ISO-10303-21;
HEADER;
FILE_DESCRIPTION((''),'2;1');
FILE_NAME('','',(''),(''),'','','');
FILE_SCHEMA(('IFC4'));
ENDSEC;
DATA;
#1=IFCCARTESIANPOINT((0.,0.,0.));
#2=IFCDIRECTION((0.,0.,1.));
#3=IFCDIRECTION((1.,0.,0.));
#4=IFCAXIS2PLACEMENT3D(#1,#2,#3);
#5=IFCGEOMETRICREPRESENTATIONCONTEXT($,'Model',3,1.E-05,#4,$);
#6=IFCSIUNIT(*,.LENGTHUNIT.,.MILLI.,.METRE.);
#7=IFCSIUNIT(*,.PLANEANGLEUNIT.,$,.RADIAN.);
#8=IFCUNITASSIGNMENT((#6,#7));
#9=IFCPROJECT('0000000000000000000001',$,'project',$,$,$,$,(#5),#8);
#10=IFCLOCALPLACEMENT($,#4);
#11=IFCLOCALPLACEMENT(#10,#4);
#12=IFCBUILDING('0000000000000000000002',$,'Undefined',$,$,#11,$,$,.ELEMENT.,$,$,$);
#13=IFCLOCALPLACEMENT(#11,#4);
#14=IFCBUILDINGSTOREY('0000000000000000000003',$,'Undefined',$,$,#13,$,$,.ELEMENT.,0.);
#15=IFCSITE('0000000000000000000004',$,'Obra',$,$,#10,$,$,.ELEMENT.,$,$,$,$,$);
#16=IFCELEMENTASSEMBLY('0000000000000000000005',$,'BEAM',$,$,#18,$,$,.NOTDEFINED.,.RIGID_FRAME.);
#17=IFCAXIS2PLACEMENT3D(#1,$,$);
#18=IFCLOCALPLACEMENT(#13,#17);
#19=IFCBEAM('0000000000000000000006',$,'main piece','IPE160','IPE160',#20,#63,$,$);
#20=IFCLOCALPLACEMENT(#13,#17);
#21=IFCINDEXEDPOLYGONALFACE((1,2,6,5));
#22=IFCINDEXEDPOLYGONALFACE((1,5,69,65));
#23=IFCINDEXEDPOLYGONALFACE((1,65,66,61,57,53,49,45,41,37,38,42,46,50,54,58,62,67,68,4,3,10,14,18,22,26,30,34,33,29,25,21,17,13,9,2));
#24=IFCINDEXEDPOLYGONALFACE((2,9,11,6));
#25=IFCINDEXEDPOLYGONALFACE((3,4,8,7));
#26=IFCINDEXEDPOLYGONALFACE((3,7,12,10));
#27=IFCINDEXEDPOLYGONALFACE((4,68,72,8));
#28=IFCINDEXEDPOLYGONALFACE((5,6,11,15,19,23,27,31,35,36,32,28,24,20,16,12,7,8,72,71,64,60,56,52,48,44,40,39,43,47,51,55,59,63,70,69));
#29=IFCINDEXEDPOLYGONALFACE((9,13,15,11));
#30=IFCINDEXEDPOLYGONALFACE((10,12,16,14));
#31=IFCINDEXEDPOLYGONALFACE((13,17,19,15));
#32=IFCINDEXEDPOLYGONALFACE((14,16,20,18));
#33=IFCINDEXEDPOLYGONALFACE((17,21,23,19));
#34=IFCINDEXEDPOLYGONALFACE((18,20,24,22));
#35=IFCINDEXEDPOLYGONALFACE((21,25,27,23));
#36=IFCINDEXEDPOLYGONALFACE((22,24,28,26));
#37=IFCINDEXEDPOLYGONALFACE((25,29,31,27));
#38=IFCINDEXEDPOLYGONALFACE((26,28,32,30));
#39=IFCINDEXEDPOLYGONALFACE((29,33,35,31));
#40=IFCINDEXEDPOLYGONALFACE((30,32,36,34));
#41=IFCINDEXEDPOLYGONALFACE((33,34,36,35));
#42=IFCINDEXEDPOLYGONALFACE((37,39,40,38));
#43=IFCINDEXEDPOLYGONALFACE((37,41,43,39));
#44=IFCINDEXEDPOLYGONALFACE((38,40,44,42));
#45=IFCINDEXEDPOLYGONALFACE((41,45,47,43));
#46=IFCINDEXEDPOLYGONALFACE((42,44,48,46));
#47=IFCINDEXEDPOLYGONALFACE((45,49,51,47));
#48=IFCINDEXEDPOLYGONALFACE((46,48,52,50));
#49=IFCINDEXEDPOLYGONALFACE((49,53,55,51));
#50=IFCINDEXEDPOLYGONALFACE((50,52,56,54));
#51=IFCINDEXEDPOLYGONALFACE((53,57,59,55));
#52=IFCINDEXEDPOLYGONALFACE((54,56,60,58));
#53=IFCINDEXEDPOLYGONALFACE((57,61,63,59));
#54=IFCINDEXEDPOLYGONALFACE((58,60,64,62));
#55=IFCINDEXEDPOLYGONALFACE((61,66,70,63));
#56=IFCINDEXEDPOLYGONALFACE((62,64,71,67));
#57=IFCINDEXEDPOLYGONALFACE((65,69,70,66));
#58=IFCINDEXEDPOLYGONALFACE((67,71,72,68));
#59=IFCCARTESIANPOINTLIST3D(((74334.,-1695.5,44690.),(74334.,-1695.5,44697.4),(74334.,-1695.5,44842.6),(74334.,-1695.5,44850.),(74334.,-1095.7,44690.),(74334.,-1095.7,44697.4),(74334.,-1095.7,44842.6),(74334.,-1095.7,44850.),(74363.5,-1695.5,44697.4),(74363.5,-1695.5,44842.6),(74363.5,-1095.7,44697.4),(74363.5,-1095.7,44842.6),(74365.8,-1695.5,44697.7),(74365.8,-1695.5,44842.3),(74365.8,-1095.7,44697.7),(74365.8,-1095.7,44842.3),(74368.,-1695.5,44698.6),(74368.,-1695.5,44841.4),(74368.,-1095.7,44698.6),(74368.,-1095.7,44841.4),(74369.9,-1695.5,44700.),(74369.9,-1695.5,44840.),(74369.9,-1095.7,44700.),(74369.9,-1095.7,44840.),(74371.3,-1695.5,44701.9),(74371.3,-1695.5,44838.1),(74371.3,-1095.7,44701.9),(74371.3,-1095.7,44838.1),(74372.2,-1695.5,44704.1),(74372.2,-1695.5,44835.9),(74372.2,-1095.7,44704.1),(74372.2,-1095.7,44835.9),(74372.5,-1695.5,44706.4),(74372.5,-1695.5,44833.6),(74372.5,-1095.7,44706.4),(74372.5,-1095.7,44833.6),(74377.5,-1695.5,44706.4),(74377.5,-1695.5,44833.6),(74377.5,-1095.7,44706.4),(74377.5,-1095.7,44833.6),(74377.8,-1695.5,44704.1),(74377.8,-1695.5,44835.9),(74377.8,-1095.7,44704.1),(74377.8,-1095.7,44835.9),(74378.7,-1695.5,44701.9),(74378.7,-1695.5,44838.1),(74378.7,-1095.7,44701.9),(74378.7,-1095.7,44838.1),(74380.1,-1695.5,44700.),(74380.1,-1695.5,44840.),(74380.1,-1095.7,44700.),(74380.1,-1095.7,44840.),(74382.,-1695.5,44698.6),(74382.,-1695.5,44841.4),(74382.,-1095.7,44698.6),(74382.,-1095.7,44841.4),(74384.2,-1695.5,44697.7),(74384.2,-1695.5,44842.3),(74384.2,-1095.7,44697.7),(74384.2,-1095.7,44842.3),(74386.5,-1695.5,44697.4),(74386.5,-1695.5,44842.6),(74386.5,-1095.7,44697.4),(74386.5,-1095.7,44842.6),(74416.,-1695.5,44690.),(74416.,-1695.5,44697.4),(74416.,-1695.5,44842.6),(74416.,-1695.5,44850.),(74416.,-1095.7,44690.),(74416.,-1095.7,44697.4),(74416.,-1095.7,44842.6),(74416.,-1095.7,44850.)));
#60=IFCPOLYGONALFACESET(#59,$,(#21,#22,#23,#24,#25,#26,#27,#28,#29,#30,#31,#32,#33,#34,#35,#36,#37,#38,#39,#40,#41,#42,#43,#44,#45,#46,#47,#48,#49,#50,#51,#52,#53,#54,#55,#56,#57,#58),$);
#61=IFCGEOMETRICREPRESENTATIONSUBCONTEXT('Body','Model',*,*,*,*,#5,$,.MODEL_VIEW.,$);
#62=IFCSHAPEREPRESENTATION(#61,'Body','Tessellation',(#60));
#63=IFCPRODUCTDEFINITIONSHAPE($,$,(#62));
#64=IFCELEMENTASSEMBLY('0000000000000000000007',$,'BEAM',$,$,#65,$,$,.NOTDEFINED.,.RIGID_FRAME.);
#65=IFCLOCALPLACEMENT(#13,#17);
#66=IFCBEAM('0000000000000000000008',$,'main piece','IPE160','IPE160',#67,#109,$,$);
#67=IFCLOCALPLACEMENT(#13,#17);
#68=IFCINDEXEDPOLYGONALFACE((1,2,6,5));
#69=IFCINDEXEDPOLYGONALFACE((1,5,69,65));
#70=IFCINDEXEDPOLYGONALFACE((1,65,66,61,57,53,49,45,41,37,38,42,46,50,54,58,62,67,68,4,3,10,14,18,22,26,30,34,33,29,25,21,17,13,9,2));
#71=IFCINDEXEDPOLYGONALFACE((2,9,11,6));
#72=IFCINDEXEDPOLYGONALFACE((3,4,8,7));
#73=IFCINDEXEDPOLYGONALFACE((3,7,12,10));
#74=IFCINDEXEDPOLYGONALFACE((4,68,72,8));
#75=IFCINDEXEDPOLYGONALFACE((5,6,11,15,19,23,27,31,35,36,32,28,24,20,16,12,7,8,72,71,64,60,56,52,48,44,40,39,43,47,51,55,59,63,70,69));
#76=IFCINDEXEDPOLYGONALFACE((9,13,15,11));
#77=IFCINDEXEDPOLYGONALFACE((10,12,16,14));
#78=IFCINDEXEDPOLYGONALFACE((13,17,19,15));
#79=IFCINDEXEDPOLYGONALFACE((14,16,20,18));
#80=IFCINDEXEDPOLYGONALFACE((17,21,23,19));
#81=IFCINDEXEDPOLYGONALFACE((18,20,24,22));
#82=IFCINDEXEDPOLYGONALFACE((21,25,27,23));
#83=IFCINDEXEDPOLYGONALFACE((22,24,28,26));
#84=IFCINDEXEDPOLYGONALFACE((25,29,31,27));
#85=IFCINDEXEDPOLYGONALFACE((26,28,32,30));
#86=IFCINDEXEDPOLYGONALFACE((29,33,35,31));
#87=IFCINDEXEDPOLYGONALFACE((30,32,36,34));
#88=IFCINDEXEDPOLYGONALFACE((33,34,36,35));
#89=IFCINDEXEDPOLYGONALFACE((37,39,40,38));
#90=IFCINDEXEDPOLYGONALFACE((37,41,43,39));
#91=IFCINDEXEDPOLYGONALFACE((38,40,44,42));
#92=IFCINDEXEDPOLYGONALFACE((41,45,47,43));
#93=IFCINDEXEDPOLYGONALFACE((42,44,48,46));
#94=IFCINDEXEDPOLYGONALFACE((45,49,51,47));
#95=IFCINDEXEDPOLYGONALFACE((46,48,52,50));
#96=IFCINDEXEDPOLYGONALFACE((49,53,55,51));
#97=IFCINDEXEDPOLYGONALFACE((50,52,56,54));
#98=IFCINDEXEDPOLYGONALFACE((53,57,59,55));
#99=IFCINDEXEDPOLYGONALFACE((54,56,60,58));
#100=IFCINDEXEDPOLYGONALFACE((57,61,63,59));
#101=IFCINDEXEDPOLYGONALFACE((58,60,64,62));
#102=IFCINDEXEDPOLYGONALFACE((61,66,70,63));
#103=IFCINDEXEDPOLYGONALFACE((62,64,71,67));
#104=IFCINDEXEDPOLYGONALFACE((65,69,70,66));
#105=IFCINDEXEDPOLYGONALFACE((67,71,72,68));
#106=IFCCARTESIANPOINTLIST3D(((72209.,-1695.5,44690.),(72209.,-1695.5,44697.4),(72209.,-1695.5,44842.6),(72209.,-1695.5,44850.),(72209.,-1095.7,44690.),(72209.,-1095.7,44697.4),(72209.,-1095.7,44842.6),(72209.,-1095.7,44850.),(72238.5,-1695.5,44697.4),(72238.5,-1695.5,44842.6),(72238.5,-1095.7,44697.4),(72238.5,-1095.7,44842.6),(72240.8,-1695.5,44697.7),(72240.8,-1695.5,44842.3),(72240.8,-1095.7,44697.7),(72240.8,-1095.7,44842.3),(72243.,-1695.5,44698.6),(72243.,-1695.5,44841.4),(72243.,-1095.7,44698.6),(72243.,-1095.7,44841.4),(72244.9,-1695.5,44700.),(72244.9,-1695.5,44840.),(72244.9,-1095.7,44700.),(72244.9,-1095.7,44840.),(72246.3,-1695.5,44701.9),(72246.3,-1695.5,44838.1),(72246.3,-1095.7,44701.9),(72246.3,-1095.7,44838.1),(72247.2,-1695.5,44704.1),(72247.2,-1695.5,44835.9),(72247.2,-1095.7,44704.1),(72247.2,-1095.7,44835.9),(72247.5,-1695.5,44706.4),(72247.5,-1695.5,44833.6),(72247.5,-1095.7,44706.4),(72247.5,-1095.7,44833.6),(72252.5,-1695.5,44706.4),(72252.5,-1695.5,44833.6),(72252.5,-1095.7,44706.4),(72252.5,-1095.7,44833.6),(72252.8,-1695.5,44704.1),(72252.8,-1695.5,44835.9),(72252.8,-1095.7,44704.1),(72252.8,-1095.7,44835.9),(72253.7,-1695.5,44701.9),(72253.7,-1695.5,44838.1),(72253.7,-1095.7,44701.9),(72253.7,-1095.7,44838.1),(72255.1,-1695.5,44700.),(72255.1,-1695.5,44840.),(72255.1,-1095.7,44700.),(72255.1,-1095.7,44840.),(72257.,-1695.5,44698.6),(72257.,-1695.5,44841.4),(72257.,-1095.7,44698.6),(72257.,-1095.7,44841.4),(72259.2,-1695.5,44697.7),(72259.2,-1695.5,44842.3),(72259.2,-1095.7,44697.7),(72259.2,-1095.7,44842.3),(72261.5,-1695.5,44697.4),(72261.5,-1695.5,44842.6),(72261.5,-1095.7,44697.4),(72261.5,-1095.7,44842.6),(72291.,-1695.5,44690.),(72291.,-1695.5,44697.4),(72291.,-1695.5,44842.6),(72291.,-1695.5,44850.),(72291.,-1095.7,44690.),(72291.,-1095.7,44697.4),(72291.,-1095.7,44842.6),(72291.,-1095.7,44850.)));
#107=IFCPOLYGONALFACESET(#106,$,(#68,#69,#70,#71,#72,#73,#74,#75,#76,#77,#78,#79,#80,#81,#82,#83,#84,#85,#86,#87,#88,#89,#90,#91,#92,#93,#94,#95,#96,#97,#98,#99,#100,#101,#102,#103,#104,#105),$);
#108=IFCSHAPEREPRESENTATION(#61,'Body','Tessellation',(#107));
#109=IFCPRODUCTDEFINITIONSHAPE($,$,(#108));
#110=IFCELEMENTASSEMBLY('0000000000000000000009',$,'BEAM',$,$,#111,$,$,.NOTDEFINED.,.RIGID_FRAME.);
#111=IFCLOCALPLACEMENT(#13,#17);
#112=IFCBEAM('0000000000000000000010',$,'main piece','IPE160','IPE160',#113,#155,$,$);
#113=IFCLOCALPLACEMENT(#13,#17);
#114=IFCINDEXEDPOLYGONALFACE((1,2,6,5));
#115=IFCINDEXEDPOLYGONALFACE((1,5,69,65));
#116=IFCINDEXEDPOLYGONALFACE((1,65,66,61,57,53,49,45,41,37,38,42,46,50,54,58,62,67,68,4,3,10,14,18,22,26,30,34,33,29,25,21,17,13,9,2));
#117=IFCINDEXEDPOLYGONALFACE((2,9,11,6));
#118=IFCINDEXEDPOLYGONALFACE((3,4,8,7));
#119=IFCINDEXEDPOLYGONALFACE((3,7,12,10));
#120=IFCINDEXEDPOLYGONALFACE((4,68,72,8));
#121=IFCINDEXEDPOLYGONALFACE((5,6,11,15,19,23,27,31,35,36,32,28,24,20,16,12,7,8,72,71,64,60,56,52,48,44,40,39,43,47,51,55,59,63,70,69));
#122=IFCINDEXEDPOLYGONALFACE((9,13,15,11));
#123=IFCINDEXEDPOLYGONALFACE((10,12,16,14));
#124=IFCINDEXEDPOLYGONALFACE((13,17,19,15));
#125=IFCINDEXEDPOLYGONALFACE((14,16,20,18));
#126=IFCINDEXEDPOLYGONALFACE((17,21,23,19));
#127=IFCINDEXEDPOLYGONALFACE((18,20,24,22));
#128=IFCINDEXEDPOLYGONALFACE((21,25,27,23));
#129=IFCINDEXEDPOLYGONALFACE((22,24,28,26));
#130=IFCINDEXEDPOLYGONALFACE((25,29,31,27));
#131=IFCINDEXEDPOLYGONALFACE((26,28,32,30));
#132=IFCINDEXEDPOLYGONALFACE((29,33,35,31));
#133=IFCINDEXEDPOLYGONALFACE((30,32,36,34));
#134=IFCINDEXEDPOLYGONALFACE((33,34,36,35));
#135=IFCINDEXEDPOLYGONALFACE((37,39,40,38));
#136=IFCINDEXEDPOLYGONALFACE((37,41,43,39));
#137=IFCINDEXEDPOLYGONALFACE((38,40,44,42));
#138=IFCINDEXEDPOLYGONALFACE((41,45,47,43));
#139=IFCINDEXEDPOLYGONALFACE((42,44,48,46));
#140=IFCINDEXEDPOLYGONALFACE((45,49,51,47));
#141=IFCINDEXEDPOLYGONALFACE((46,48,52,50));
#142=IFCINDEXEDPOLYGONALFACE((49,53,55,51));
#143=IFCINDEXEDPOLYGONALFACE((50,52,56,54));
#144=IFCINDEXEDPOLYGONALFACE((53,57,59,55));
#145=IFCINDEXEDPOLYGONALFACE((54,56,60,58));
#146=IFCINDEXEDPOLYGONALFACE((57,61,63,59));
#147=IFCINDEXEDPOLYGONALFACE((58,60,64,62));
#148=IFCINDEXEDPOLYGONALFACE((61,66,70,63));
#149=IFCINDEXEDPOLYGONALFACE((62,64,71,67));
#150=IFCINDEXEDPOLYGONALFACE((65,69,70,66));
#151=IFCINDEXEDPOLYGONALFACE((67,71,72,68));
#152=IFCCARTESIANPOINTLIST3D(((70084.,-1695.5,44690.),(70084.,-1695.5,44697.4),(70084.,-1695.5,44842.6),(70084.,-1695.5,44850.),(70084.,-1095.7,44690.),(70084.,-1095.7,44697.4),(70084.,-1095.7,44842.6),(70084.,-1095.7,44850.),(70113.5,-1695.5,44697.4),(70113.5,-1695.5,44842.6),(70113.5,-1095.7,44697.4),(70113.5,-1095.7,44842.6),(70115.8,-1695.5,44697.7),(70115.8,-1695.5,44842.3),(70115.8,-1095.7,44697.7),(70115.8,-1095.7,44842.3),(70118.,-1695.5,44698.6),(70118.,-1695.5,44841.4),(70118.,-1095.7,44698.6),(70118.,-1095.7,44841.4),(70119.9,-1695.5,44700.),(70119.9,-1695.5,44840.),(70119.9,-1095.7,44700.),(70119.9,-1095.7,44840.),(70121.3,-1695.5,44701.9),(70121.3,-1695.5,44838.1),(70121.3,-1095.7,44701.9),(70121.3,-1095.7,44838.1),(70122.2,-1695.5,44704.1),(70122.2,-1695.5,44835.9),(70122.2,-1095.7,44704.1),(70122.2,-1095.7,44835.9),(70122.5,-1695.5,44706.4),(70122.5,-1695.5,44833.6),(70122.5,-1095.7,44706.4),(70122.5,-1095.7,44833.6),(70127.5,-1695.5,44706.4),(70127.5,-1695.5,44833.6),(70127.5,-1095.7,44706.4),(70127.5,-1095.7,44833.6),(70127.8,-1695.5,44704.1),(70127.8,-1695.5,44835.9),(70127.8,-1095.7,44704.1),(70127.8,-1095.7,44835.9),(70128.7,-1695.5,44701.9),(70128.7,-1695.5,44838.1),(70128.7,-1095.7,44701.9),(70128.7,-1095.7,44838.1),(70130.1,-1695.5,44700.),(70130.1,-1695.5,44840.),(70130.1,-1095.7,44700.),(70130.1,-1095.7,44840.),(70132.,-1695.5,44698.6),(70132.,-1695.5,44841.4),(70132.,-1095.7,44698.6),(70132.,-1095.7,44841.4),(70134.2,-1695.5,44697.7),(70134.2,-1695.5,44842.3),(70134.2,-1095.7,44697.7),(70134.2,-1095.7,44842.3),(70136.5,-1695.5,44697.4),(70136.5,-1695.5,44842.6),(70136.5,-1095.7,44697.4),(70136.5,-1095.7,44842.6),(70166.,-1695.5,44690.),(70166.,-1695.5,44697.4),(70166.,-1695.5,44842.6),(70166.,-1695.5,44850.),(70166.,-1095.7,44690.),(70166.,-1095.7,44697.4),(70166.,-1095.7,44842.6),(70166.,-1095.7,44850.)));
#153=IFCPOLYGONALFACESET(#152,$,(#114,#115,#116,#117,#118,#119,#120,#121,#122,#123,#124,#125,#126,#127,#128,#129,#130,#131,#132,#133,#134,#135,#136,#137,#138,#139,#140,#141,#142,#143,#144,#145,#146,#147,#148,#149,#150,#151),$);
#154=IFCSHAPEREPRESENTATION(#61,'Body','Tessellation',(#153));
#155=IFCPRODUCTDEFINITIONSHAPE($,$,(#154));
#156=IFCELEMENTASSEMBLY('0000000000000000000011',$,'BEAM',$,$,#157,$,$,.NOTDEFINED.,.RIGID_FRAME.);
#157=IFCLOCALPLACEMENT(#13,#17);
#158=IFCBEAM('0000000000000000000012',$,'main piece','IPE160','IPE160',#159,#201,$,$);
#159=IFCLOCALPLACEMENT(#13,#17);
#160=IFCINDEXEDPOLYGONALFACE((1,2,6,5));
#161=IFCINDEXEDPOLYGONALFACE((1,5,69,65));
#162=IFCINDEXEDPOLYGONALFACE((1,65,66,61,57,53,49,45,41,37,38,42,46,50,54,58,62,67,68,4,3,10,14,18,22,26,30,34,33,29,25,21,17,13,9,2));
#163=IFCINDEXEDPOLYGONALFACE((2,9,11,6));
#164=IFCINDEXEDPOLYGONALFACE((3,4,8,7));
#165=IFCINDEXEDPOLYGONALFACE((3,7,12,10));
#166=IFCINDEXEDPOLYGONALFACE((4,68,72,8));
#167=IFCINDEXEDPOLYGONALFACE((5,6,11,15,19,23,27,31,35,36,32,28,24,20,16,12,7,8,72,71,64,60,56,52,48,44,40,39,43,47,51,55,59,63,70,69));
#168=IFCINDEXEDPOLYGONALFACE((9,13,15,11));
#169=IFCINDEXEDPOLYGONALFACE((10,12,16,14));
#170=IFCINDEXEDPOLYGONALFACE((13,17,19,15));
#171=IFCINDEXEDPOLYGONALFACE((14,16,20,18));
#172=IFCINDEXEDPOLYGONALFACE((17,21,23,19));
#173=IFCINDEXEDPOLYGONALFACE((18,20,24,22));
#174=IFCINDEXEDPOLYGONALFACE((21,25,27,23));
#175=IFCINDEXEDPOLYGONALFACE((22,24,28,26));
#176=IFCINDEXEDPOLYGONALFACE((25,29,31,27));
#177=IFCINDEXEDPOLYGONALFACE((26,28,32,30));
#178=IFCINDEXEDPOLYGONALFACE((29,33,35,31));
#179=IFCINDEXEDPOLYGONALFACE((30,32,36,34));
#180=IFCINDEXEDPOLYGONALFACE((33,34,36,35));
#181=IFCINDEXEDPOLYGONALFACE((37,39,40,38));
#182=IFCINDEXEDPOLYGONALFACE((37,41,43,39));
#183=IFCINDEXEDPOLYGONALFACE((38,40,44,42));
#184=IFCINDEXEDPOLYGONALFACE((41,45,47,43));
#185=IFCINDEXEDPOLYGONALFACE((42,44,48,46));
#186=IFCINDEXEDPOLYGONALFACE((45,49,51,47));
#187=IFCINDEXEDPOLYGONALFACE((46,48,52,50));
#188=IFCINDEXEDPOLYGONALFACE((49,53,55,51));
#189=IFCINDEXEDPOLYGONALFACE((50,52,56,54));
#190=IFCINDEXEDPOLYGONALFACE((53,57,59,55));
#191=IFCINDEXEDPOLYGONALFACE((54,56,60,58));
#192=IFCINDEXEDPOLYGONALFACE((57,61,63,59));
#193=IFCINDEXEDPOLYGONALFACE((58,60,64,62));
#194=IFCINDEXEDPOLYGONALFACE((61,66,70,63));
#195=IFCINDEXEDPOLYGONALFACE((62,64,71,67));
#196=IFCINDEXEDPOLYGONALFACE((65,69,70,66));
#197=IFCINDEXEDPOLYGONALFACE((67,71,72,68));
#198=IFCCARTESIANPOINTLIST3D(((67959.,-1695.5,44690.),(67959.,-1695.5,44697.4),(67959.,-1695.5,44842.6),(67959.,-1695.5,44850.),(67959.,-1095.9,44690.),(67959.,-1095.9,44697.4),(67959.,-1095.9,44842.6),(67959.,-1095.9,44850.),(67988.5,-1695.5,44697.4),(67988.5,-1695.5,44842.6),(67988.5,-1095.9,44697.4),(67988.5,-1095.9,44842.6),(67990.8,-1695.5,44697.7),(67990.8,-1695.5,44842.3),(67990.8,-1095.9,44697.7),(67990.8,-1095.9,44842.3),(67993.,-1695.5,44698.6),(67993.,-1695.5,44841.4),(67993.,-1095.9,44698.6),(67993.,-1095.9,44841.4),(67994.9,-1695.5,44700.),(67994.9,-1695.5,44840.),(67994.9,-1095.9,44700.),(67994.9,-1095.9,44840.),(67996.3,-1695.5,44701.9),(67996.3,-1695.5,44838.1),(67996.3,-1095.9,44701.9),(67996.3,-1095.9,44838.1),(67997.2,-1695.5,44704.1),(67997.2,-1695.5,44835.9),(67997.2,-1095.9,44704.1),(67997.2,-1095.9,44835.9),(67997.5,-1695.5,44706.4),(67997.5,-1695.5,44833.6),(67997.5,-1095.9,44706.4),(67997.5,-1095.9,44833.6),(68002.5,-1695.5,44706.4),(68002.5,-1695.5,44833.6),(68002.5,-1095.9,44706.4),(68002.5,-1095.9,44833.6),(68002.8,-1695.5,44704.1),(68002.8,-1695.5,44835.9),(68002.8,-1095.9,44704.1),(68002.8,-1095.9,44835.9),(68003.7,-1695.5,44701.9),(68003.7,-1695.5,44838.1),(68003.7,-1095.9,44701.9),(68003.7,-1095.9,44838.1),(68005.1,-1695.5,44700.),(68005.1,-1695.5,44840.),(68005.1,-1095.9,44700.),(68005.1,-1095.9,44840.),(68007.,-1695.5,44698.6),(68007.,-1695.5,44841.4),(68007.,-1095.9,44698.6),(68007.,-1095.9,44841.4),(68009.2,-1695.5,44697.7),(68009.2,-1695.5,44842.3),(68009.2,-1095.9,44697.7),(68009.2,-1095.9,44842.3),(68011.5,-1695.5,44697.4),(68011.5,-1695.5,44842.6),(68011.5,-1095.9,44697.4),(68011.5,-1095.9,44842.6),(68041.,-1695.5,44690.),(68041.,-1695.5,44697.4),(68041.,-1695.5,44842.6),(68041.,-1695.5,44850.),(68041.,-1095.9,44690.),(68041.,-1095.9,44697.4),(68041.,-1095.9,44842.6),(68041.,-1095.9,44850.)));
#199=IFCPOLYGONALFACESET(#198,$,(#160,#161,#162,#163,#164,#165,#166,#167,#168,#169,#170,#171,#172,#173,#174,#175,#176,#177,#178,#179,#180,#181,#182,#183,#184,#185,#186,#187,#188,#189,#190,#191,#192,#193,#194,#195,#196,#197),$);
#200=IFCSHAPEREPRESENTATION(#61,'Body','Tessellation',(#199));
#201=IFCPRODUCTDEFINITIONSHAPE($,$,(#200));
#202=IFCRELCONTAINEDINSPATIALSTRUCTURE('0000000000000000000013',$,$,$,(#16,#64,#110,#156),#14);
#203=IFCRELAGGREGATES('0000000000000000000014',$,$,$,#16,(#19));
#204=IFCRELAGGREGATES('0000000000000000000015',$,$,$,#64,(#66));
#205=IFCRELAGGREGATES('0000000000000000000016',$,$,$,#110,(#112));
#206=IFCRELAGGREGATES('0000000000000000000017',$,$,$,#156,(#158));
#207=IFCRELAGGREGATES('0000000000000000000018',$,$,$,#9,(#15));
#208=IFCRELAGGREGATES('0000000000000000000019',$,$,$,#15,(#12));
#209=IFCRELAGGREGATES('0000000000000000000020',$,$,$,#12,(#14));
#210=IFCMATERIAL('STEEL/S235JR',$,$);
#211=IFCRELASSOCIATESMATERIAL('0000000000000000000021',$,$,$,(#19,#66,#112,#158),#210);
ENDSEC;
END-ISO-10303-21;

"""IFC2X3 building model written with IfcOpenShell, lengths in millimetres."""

from ifc_helpers import new_model, si_unit, frame, origin_with_axes, origin_2d_with_axis, place, context, subcontext, project, spatial, i_section, extrude, material, element, aggregate, save


model = new_model("IFC2X3")

# Units and contexts
model_context = context("Model", 3, precision=1e-05, world=origin_with_axes())
body_context = subcontext(model_context, "Body", "Model", "MODEL_VIEW")
ifc_project = project(units=[si_unit("LENGTHUNIT", "METRE", prefix="MILLI"), si_unit("PLANEANGLEUNIT", "RADIAN")], contexts=[model_context])

# Site, building, storey
site_placement = place(None, origin_with_axes())
site = spatial("IfcSite", under=ifc_project, at=site_placement, Name="Obra", CompositionType="ELEMENT")
building_placement = place(site_placement, origin_with_axes())
building = spatial("IfcBuilding", under=site, at=building_placement, Name="Undefined", CompositionType="ELEMENT")
storey_placement = place(building_placement, origin_with_axes())
storey = spatial("IfcBuildingStorey", under=building, at=storey_placement, Name="Undefined", CompositionType="ELEMENT", Elevation=0.0)

# Element assemblies, beams
ifc_material_1 = material(Name="STEEL/S235JR")
assembly_1_placement = place(storey_placement, origin_with_axes())
assembly_1 = element("IfcElementAssembly", 1, at=assembly_1_placement, inside=storey, Name="BEAM", AssemblyPlace="NOTDEFINED", PredefinedType="RIGID_FRAME")
beam_1_placement = place(assembly_1_placement, frame((74375.0, -1095.7, 44770.0), z_axis=(0.0, 0.0, 1.0), x_axis=(0.0, -1.0, 0.0)))
beam_1 = element("IfcBeam", 2, at=beam_1_placement, material=ifc_material_1, Name="main piece", Description="IPE160", ObjectType="IPE160", context=body_context, shape_type="SweptSolid", body=[
    extrude(i_section(OverallWidth=82.0, OverallDepth=160.0, WebThickness=5.0, FlangeThickness=7.4, FilletRadius=9.0, at=origin_2d_with_axis()), frame((599.8, 0.0, 0.0), z_axis=(-1.0, 0.0, 0.0), x_axis=(0.0, -1.0, 0.0)), (0.0, 0.0, 1.0), 599.8),
])
aggregate(assembly_1, [beam_1])
assembly_2_placement = place(storey_placement, origin_with_axes())
assembly_2 = element("IfcElementAssembly", 3, at=assembly_2_placement, inside=storey, Name="BEAM", AssemblyPlace="NOTDEFINED", PredefinedType="RIGID_FRAME")
beam_2_placement = place(assembly_2_placement, frame((72250.0, -1095.7, 44770.0), z_axis=(0.0, 0.0, 1.0), x_axis=(0.0, -1.0, 0.0)))
beam_2 = element("IfcBeam", 4, at=beam_2_placement, material=ifc_material_1, Name="main piece", Description="IPE160", ObjectType="IPE160", context=body_context, shape_type="SweptSolid", body=[
    extrude(i_section(OverallWidth=82.0, OverallDepth=160.0, WebThickness=5.0, FlangeThickness=7.4, FilletRadius=9.0, at=origin_2d_with_axis()), frame((599.8, 0.0, 0.0), z_axis=(-1.0, 0.0, 0.0), x_axis=(0.0, -1.0, 0.0)), (0.0, 0.0, 1.0), 599.8),
])
aggregate(assembly_2, [beam_2])
assembly_3_placement = place(storey_placement, origin_with_axes())
assembly_3 = element("IfcElementAssembly", 5, at=assembly_3_placement, inside=storey, Name="BEAM", AssemblyPlace="NOTDEFINED", PredefinedType="RIGID_FRAME")
beam_3_placement = place(assembly_3_placement, frame((70125.0, -1695.5, 44770.0), z_axis=(0.0, 0.0, 1.0), x_axis=(0.0, 1.0, 0.0)))
beam_3 = element("IfcBeam", 6, at=beam_3_placement, material=ifc_material_1, Name="main piece", Description="IPE160", ObjectType="IPE160", context=body_context, shape_type="SweptSolid", body=[
    extrude(i_section(OverallWidth=82.0, OverallDepth=160.0, WebThickness=5.0, FlangeThickness=7.4, FilletRadius=9.0, at=origin_2d_with_axis()), frame((599.8, 0.0, 0.0), z_axis=(-1.0, 0.0, 0.0), x_axis=(0.0, -1.0, 0.0)), (0.0, 0.0, 1.0), 599.8),
])
aggregate(assembly_3, [beam_3])
assembly_4_placement = place(storey_placement, origin_with_axes())
assembly_4 = element("IfcElementAssembly", 7, at=assembly_4_placement, inside=storey, Name="BEAM", AssemblyPlace="NOTDEFINED", PredefinedType="RIGID_FRAME")
beam_4_placement = place(assembly_4_placement, frame((68000.0, -1095.9, 44770.0), z_axis=(0.0, 0.0, 1.0), x_axis=(0.0, -1.0, 0.0)))
beam_4 = element("IfcBeam", 8, at=beam_4_placement, material=ifc_material_1, Name="main piece", Description="IPE160", ObjectType="IPE160", context=body_context, shape_type="SweptSolid", body=[
    extrude(i_section(OverallWidth=82.0, OverallDepth=160.0, WebThickness=5.0, FlangeThickness=7.4, FilletRadius=9.0, at=origin_2d_with_axis()), frame((599.6, 0.0, 0.0), z_axis=(-1.0, 0.0, 0.0), x_axis=(0.0, -1.0, 0.0)), (0.0, 0.0, 1.0), 599.6),
])
aggregate(assembly_4, [beam_4])

save(model, "model.ifc")
